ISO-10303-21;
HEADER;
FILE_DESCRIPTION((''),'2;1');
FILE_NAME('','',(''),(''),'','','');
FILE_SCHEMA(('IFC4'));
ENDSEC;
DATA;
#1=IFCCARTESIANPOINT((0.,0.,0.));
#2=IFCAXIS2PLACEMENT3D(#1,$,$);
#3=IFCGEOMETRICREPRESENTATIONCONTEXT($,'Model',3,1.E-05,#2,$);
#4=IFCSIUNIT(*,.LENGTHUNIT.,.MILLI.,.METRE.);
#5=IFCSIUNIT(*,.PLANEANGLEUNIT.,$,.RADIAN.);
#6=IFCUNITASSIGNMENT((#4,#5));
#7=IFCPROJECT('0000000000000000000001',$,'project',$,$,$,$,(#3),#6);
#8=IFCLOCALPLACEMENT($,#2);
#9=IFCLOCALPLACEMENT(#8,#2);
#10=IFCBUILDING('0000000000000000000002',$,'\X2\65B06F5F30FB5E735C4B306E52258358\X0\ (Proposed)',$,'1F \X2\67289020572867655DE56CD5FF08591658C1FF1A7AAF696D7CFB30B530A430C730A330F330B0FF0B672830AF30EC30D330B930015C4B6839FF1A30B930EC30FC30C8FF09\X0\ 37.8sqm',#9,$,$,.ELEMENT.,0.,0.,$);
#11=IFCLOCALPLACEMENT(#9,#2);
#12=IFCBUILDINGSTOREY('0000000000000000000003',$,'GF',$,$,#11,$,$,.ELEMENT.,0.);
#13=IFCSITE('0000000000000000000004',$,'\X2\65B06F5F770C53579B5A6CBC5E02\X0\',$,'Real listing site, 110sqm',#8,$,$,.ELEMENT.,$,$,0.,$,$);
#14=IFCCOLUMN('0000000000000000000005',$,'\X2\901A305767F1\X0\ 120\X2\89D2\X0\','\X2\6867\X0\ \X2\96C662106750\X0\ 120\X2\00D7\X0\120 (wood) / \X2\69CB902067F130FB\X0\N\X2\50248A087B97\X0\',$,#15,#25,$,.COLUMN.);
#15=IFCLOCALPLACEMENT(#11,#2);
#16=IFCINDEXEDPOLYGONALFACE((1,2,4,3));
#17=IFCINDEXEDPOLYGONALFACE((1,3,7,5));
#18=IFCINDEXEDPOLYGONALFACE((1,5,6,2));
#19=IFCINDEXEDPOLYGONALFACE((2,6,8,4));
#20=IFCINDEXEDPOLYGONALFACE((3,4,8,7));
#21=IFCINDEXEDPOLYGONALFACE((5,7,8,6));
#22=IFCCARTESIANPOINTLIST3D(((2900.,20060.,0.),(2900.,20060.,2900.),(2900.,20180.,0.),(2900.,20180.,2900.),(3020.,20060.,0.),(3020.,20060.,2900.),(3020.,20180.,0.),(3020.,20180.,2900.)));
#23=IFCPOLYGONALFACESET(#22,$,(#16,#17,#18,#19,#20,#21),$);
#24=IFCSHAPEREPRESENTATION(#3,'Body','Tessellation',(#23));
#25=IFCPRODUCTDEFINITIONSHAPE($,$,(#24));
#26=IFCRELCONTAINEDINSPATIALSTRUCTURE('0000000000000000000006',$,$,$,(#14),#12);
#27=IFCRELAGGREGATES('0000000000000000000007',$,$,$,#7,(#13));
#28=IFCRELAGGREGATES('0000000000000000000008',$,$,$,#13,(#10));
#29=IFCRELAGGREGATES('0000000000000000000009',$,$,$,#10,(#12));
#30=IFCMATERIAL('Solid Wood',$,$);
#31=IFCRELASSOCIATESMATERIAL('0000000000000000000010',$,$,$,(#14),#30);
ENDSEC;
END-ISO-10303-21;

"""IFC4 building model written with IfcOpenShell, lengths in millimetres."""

from ifc_helpers import new_model, si_unit, frame, frame_2d, origin, place, context, project, spatial, rectangle, extrude, material, element, save


model = new_model("IFC4")

# Units and contexts
model_context = context("Model", 3, precision=1e-05, world=origin())
ifc_project = project(units=[si_unit("LENGTHUNIT", "METRE", prefix="MILLI"), si_unit("PLANEANGLEUNIT", "RADIAN")], contexts=[model_context])

# Site, building, storey
site_placement = place(None, origin())
site = spatial("IfcSite", under=ifc_project, at=site_placement, Name="新潟県南魚沼市", ObjectType="Real listing site, 110sqm", CompositionType="ELEMENT", RefElevation=0.0)
building_placement = place(site_placement, origin())
building = spatial("IfcBuilding", under=site, at=building_placement, Name="新潟・平屋の別荘 (Proposed)", ObjectType="1F 木造在来工法（外壁：窯業系サイディング＋木クレビス、屋根：スレート） 37.8sqm", CompositionType="ELEMENT", ElevationOfRefHeight=0.0, ElevationOfTerrain=0.0)
storey_placement = place(building_placement, origin())
storey = spatial("IfcBuildingStorey", under=building, at=storey_placement, Name="GF", CompositionType="ELEMENT", Elevation=0.0)

# Column
ifc_material_1 = material(Name="Solid Wood")
column_1_placement = place(storey_placement, frame((1450.0, 10030.0, 0.0)))
element("IfcColumn", 1, at=column_1_placement, inside=storey, material=ifc_material_1, Name="通し柱 120角", Description="桧 集成材 120×120 (wood) / 構造柱・N値計算", PredefinedType="COLUMN", context=model_context, shape_type="SweptSolid", body=[
    extrude(rectangle(XDim=120.0, YDim=120.0, at=frame_2d((60.0, 60.0))), frame((1450.0, 10030.0, 0.0)), (0.0, 0.0, 1.0), 2900.0),
])

save(model, "model.ifc")
